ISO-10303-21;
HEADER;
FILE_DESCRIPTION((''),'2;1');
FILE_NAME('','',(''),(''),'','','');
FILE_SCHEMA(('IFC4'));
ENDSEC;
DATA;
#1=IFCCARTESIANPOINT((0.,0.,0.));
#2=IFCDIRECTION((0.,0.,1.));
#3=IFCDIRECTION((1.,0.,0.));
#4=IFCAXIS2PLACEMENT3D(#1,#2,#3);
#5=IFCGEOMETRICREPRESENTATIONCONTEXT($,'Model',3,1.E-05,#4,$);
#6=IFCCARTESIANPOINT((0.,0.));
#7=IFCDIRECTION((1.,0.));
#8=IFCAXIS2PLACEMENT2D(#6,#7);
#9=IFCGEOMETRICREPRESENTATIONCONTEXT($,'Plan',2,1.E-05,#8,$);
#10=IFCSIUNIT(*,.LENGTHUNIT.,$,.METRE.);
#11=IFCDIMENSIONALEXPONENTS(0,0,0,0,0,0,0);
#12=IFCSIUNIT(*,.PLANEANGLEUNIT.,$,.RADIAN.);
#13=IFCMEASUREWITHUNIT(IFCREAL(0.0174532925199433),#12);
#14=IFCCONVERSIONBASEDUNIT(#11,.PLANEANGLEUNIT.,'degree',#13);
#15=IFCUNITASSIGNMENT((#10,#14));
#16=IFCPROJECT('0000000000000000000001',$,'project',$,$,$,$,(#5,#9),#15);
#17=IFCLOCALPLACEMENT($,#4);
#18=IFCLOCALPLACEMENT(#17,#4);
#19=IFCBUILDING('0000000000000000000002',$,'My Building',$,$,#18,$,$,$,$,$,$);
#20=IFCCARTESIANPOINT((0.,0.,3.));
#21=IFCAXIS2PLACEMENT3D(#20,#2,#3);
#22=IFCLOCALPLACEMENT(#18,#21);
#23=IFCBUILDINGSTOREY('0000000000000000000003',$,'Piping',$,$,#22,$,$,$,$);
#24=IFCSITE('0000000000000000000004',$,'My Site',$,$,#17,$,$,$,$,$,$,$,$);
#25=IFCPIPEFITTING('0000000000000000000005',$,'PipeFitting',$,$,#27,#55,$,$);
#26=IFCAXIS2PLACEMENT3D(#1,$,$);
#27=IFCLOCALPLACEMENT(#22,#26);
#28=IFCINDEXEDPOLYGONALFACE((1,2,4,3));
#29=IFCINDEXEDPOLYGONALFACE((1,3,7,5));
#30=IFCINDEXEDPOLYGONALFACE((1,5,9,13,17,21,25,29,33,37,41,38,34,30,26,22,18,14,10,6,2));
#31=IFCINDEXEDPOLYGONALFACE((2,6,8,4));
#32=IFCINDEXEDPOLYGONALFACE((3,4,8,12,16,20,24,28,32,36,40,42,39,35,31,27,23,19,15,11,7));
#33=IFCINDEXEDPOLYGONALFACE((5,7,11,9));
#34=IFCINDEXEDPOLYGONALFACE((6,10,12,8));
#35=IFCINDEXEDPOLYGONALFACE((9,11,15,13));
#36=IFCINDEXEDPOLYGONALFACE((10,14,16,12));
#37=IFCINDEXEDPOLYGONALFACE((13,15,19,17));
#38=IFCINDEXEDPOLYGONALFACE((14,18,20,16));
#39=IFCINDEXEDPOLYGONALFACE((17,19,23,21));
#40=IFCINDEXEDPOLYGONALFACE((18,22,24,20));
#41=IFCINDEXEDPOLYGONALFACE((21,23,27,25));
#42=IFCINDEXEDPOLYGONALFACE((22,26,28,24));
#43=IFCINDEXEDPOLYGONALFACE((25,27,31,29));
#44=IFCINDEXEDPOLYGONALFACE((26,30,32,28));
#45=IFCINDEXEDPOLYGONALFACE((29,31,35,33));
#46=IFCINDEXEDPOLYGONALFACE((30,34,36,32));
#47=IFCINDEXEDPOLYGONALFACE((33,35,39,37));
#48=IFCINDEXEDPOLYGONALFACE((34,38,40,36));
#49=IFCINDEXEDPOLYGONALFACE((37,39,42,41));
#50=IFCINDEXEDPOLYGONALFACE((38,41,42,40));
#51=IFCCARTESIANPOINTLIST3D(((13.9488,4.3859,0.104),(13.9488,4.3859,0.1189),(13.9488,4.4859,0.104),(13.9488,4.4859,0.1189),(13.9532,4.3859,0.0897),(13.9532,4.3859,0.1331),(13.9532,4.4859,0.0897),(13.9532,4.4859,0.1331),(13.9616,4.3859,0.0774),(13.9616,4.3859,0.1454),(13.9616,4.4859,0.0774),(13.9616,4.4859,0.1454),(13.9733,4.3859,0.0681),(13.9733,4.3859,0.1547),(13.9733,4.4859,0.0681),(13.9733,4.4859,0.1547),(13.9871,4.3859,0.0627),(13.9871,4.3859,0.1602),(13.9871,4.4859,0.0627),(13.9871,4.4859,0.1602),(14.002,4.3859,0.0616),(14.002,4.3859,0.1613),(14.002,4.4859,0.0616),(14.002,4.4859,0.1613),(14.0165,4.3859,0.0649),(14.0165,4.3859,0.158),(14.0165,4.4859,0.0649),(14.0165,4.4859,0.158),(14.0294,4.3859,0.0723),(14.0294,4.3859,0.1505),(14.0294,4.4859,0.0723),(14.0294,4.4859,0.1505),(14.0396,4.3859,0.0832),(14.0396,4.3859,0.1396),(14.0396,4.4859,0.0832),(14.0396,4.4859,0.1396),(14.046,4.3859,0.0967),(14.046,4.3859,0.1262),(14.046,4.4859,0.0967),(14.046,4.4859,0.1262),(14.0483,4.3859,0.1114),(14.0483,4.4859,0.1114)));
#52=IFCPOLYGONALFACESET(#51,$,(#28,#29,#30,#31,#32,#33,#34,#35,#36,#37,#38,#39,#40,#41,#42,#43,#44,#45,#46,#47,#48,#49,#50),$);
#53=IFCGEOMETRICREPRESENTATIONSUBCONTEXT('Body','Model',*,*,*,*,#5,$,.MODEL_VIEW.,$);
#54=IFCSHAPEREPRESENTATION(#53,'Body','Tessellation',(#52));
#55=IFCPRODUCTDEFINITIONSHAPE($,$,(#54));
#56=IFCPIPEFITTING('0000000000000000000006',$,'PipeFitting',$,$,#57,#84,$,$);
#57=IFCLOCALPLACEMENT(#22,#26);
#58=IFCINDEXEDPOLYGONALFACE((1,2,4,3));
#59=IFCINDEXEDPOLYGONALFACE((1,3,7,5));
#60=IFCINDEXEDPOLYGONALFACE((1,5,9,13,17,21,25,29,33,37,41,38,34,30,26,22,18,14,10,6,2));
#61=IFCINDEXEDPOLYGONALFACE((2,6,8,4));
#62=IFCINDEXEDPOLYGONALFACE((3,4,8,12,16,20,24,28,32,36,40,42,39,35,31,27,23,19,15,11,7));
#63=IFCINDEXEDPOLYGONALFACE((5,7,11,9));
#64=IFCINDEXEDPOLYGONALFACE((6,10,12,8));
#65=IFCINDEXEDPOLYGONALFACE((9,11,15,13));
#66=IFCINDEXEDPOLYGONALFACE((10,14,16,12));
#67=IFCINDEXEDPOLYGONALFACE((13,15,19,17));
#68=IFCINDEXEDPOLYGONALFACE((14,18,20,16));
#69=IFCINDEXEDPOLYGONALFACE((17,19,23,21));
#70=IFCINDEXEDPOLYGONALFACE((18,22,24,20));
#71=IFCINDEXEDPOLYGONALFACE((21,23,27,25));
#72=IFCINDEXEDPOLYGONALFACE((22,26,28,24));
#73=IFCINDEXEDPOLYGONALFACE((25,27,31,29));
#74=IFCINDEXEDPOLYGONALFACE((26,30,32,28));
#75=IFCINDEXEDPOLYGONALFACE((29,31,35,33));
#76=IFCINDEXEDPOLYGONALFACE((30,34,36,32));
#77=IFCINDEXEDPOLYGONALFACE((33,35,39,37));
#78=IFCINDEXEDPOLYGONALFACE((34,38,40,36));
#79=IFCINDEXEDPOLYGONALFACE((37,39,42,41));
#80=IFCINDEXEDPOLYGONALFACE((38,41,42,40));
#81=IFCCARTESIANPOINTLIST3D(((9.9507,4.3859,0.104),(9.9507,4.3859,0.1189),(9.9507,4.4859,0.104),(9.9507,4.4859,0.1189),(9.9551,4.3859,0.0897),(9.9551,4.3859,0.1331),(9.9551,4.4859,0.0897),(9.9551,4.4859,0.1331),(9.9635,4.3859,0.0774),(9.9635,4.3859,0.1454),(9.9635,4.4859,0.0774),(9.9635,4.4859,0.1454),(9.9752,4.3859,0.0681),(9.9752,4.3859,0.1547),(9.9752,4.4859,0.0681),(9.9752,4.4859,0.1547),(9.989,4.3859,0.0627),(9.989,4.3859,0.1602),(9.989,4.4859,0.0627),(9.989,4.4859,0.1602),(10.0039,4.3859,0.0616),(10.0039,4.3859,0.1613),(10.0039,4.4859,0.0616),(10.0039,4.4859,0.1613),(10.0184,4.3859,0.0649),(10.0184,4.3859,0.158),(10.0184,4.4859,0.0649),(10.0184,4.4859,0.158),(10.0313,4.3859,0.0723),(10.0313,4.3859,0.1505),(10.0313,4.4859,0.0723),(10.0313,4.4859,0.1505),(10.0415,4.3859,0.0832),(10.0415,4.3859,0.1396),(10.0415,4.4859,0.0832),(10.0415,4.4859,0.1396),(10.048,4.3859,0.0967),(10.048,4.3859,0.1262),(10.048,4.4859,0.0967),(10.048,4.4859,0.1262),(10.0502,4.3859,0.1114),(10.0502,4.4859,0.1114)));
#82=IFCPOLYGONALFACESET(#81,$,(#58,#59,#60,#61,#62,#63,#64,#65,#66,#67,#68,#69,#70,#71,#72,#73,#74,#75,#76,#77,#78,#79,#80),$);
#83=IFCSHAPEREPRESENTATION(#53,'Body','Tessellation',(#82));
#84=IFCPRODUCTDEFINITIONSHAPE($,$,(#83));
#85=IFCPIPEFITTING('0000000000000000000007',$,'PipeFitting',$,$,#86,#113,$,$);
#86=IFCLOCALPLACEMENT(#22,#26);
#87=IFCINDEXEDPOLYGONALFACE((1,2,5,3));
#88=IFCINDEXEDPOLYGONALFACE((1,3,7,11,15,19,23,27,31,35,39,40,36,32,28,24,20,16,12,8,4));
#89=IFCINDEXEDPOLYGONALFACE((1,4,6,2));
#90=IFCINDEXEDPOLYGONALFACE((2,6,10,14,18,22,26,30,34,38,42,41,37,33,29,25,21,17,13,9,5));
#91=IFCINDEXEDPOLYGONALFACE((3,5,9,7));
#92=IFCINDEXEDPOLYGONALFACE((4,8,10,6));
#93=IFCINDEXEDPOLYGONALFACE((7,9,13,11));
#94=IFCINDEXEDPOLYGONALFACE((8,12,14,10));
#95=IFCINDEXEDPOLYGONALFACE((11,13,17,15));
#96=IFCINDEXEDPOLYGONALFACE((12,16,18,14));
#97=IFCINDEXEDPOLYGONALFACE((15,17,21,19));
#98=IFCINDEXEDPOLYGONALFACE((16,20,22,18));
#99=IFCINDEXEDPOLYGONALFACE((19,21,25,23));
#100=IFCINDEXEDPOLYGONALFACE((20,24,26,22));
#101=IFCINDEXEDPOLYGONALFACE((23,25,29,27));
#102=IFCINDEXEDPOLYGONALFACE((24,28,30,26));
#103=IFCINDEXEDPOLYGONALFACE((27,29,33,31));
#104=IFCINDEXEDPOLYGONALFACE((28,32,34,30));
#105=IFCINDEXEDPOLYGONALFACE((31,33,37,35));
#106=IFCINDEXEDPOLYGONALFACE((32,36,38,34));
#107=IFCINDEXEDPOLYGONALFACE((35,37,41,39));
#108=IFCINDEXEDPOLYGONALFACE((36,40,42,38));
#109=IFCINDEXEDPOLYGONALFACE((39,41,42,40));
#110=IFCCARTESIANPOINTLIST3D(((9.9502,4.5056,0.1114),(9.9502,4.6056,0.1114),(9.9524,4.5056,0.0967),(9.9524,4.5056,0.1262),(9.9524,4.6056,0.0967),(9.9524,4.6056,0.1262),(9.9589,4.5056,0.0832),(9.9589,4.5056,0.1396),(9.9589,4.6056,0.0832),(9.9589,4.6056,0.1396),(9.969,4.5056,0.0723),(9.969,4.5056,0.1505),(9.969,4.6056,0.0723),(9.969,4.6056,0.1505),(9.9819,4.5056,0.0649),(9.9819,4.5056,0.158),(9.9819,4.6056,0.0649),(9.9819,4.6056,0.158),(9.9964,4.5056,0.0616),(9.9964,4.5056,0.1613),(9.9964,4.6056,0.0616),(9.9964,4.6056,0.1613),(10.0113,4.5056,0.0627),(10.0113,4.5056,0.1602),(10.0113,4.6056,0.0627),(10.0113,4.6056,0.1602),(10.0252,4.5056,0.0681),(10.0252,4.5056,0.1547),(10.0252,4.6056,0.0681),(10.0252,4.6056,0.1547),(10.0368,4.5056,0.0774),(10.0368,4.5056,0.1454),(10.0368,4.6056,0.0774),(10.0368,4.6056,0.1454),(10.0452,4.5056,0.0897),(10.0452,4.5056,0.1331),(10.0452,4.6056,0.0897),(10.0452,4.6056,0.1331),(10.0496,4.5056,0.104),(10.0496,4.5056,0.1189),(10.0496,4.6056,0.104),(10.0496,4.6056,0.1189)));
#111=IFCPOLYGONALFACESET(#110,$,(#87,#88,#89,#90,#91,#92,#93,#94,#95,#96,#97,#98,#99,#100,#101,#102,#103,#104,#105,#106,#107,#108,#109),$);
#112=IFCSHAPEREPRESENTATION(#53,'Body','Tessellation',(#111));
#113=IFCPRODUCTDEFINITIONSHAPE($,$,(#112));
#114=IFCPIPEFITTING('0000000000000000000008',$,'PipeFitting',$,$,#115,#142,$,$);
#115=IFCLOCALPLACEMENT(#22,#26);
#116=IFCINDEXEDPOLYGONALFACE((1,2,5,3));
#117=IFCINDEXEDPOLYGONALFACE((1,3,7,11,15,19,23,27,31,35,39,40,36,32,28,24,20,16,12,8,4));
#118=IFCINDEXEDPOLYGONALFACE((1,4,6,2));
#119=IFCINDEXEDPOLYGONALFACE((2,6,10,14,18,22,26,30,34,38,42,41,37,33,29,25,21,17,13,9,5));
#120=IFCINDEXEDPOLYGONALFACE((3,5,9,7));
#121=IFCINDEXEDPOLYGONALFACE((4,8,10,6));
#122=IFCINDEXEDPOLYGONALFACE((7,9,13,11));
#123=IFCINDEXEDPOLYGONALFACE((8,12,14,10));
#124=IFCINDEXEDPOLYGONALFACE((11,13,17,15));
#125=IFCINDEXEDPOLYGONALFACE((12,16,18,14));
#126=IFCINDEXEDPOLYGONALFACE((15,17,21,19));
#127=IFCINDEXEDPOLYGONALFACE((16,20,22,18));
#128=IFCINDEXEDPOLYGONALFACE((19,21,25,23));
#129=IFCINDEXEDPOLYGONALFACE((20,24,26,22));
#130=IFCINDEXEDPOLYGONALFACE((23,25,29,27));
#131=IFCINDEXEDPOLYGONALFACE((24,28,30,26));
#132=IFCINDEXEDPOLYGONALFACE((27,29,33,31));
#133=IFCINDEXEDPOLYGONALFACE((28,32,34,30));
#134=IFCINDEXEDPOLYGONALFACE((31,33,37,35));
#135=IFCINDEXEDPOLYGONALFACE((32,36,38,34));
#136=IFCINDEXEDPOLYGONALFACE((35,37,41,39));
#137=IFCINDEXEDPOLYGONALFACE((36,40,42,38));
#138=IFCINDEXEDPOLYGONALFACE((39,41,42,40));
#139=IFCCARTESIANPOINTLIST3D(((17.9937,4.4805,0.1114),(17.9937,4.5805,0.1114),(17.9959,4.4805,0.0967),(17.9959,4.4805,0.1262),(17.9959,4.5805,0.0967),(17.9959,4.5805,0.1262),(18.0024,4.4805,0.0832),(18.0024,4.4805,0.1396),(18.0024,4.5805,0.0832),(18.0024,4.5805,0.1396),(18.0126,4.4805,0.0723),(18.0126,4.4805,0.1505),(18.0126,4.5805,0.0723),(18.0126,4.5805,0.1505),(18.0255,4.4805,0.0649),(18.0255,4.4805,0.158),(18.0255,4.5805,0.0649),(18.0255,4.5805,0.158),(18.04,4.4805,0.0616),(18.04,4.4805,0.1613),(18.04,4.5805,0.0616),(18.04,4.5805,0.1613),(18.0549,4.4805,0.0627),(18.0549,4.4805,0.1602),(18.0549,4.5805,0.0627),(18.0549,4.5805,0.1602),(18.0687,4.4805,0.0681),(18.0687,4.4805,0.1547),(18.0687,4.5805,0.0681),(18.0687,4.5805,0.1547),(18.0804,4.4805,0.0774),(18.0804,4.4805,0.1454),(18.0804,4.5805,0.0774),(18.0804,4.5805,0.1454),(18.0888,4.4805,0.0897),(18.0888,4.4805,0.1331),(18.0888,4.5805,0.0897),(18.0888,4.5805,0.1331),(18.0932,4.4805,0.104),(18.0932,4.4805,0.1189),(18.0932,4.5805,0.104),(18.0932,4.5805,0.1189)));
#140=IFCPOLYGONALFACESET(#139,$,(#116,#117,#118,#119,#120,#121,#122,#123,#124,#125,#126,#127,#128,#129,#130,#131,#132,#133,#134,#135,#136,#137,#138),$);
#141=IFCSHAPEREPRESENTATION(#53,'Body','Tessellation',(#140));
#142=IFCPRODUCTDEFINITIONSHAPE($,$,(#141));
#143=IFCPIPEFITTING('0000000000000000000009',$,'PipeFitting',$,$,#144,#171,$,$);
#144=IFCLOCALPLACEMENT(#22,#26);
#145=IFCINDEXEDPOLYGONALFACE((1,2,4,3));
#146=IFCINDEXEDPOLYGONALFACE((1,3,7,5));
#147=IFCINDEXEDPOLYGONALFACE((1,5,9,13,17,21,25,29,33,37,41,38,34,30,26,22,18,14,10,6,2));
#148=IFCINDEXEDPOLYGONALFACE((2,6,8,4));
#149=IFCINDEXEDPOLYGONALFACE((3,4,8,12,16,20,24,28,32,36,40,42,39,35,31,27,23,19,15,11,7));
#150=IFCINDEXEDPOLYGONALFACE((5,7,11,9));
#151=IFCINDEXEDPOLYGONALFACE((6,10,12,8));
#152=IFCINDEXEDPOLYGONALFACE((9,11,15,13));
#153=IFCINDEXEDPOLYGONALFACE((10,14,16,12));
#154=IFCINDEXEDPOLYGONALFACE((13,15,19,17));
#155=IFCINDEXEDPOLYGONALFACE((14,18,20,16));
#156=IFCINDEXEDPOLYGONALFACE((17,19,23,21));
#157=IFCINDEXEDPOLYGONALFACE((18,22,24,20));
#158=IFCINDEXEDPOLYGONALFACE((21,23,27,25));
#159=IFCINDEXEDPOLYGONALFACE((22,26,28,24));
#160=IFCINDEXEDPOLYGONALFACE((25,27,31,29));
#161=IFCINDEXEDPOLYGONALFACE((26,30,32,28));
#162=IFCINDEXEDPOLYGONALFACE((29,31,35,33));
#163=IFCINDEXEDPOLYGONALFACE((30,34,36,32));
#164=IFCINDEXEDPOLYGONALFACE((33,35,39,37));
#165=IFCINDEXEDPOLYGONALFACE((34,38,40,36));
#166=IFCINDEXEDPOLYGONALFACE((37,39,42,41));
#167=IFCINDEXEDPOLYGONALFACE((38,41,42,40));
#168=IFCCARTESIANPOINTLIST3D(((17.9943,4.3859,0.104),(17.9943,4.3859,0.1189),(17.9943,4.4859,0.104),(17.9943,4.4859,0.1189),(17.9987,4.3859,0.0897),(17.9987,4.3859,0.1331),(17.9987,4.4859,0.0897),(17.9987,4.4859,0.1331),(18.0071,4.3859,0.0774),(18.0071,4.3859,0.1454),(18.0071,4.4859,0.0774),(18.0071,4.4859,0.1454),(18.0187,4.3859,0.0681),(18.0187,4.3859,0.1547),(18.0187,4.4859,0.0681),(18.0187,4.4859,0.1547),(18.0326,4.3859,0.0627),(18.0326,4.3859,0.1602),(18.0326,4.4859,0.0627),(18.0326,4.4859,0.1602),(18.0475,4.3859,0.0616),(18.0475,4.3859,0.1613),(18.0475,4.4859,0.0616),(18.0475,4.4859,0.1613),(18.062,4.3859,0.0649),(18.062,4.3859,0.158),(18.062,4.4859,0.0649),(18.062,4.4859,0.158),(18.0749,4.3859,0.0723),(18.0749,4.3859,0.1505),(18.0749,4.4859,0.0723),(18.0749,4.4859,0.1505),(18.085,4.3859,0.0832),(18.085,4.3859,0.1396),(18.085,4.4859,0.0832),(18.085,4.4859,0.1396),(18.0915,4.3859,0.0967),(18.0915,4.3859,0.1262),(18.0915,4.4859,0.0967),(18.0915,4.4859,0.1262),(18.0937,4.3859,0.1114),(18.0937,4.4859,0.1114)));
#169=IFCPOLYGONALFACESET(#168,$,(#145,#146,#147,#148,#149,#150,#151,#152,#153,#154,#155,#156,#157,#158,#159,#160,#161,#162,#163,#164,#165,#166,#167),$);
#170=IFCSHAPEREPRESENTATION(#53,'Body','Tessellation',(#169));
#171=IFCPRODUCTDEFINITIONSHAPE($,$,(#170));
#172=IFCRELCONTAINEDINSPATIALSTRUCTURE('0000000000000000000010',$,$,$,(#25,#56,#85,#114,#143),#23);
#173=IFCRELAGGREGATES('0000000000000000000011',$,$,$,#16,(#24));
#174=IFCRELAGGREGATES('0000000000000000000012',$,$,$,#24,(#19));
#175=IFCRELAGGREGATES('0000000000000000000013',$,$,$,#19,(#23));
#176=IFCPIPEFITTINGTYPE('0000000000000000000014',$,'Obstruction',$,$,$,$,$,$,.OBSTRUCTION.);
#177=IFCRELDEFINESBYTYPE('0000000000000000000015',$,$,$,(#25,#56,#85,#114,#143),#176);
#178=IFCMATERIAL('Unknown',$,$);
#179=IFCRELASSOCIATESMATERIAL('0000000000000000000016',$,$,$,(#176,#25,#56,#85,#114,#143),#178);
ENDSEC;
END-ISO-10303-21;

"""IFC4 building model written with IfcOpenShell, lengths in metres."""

from ifc_helpers import new_model, entity, si_unit, converted_unit, frame, origin_with_axes, origin_2d_with_axis, place, context, subcontext, project, spatial, circle, extrude, material, material_profile, profile_set, profile_usage, type_object, element, save


model = new_model("IFC4")

# Units and contexts
model_context = context("Model", 3, precision=1e-05, world=origin_with_axes())
plan_context = context("Plan", 2, precision=1e-05, world=origin_2d_with_axis())
body_context = subcontext(model_context, "Body", "Model", "MODEL_VIEW")
ifc_project = project(units=[si_unit("LENGTHUNIT", "METRE"), converted_unit("PLANEANGLEUNIT", "degree", entity("IfcReal", 0.0174532925199433), si_unit("PLANEANGLEUNIT", "RADIAN"), dimensions=[0, 0, 0, 0, 0, 0, 0])], contexts=[model_context, plan_context])

# Site, building, storey
site_placement = place(None, origin_with_axes())
site = spatial("IfcSite", under=ifc_project, at=site_placement, Name="My Site")
building_placement = place(site_placement, origin_with_axes())
building = spatial("IfcBuilding", under=site, at=building_placement, Name="My Building")
storey_placement = place(building_placement, frame((0.0, 0.0, 3.0), z_axis=(0.0, 0.0, 1.0), x_axis=(1.0, 0.0, 0.0)))
storey = spatial("IfcBuildingStorey", under=building, at=storey_placement, Name="Piping")

# Shared definitions
ifc_material = material(Name="Unknown")

# Pipe fittings
ifc_material_profile_1 = material_profile(ifc_material, circle(Radius=0.05))
ifc_profile_set_1 = profile_set([ifc_material_profile_1])
pipe_fitting_type_1 = type_object("IfcPipeFittingType", Name="Obstruction", PredefinedType="OBSTRUCTION", material=ifc_profile_set_1)
ifc_profile_usage_1 = profile_usage(ifc_profile_set_1, cardinal=16)
pipe_fitting_1_placement = place(storey_placement, frame((13.9983, 4.4859, 0.1114), z_axis=(0.0, -1.0, 0.0), x_axis=(1.0, 0.0, 0.0)))
element("IfcPipeFitting", 1, at=pipe_fitting_1_placement, inside=storey, type_object=pipe_fitting_type_1, material=ifc_profile_usage_1, Name="PipeFitting", context=body_context, shape_type="SweptSolid", body=[
    extrude(circle(Radius=0.05), origin_with_axes(), (0.0, 0.0, 1.0), 0.1),
])
ifc_profile_usage_2 = profile_usage(ifc_profile_set_1, cardinal=16)
pipe_fitting_2_placement = place(storey_placement, frame((10.0002, 4.4859, 0.1114), z_axis=(0.0, -1.0, 0.0), x_axis=(1.0, 0.0, 0.0)))
element("IfcPipeFitting", 2, at=pipe_fitting_2_placement, inside=storey, type_object=pipe_fitting_type_1, material=ifc_profile_usage_2, Name="PipeFitting", context=body_context, shape_type="SweptSolid", body=[
    extrude(circle(Radius=0.05), origin_with_axes(), (0.0, 0.0, 1.0), 0.1),
])
ifc_profile_usage_3 = profile_usage(ifc_profile_set_1, cardinal=16)
pipe_fitting_3_placement = place(storey_placement, frame((10.0002, 4.5056, 0.1114), z_axis=(0.0, 1.0, 0.0), x_axis=(-1.0, 0.0, 0.0)))
element("IfcPipeFitting", 3, at=pipe_fitting_3_placement, inside=storey, type_object=pipe_fitting_type_1, material=ifc_profile_usage_3, Name="PipeFitting", context=body_context, shape_type="SweptSolid", body=[
    extrude(circle(Radius=0.05), origin_with_axes(), (0.0, 0.0, 1.0), 0.1),
])
ifc_profile_usage_4 = profile_usage(ifc_profile_set_1, cardinal=16)
pipe_fitting_4_placement = place(storey_placement, frame((18.0437, 4.4805, 0.1114), z_axis=(0.0, 1.0, 0.0), x_axis=(-1.0, 0.0, 0.0)))
element("IfcPipeFitting", 4, at=pipe_fitting_4_placement, inside=storey, type_object=pipe_fitting_type_1, material=ifc_profile_usage_4, Name="PipeFitting", context=body_context, shape_type="SweptSolid", body=[
    extrude(circle(Radius=0.05), origin_with_axes(), (0.0, 0.0, 1.0), 0.1),
])
ifc_profile_usage_5 = profile_usage(ifc_profile_set_1, cardinal=16)
pipe_fitting_5_placement = place(storey_placement, frame((18.0437, 4.4859, 0.1114), z_axis=(0.0, -1.0, 0.0), x_axis=(1.0, 0.0, 0.0)))
element("IfcPipeFitting", 5, at=pipe_fitting_5_placement, inside=storey, type_object=pipe_fitting_type_1, material=ifc_profile_usage_5, Name="PipeFitting", context=body_context, shape_type="SweptSolid", body=[
    extrude(circle(Radius=0.05), origin_with_axes(), (0.0, 0.0, 1.0), 0.1),
])

save(model, "model.ifc")
